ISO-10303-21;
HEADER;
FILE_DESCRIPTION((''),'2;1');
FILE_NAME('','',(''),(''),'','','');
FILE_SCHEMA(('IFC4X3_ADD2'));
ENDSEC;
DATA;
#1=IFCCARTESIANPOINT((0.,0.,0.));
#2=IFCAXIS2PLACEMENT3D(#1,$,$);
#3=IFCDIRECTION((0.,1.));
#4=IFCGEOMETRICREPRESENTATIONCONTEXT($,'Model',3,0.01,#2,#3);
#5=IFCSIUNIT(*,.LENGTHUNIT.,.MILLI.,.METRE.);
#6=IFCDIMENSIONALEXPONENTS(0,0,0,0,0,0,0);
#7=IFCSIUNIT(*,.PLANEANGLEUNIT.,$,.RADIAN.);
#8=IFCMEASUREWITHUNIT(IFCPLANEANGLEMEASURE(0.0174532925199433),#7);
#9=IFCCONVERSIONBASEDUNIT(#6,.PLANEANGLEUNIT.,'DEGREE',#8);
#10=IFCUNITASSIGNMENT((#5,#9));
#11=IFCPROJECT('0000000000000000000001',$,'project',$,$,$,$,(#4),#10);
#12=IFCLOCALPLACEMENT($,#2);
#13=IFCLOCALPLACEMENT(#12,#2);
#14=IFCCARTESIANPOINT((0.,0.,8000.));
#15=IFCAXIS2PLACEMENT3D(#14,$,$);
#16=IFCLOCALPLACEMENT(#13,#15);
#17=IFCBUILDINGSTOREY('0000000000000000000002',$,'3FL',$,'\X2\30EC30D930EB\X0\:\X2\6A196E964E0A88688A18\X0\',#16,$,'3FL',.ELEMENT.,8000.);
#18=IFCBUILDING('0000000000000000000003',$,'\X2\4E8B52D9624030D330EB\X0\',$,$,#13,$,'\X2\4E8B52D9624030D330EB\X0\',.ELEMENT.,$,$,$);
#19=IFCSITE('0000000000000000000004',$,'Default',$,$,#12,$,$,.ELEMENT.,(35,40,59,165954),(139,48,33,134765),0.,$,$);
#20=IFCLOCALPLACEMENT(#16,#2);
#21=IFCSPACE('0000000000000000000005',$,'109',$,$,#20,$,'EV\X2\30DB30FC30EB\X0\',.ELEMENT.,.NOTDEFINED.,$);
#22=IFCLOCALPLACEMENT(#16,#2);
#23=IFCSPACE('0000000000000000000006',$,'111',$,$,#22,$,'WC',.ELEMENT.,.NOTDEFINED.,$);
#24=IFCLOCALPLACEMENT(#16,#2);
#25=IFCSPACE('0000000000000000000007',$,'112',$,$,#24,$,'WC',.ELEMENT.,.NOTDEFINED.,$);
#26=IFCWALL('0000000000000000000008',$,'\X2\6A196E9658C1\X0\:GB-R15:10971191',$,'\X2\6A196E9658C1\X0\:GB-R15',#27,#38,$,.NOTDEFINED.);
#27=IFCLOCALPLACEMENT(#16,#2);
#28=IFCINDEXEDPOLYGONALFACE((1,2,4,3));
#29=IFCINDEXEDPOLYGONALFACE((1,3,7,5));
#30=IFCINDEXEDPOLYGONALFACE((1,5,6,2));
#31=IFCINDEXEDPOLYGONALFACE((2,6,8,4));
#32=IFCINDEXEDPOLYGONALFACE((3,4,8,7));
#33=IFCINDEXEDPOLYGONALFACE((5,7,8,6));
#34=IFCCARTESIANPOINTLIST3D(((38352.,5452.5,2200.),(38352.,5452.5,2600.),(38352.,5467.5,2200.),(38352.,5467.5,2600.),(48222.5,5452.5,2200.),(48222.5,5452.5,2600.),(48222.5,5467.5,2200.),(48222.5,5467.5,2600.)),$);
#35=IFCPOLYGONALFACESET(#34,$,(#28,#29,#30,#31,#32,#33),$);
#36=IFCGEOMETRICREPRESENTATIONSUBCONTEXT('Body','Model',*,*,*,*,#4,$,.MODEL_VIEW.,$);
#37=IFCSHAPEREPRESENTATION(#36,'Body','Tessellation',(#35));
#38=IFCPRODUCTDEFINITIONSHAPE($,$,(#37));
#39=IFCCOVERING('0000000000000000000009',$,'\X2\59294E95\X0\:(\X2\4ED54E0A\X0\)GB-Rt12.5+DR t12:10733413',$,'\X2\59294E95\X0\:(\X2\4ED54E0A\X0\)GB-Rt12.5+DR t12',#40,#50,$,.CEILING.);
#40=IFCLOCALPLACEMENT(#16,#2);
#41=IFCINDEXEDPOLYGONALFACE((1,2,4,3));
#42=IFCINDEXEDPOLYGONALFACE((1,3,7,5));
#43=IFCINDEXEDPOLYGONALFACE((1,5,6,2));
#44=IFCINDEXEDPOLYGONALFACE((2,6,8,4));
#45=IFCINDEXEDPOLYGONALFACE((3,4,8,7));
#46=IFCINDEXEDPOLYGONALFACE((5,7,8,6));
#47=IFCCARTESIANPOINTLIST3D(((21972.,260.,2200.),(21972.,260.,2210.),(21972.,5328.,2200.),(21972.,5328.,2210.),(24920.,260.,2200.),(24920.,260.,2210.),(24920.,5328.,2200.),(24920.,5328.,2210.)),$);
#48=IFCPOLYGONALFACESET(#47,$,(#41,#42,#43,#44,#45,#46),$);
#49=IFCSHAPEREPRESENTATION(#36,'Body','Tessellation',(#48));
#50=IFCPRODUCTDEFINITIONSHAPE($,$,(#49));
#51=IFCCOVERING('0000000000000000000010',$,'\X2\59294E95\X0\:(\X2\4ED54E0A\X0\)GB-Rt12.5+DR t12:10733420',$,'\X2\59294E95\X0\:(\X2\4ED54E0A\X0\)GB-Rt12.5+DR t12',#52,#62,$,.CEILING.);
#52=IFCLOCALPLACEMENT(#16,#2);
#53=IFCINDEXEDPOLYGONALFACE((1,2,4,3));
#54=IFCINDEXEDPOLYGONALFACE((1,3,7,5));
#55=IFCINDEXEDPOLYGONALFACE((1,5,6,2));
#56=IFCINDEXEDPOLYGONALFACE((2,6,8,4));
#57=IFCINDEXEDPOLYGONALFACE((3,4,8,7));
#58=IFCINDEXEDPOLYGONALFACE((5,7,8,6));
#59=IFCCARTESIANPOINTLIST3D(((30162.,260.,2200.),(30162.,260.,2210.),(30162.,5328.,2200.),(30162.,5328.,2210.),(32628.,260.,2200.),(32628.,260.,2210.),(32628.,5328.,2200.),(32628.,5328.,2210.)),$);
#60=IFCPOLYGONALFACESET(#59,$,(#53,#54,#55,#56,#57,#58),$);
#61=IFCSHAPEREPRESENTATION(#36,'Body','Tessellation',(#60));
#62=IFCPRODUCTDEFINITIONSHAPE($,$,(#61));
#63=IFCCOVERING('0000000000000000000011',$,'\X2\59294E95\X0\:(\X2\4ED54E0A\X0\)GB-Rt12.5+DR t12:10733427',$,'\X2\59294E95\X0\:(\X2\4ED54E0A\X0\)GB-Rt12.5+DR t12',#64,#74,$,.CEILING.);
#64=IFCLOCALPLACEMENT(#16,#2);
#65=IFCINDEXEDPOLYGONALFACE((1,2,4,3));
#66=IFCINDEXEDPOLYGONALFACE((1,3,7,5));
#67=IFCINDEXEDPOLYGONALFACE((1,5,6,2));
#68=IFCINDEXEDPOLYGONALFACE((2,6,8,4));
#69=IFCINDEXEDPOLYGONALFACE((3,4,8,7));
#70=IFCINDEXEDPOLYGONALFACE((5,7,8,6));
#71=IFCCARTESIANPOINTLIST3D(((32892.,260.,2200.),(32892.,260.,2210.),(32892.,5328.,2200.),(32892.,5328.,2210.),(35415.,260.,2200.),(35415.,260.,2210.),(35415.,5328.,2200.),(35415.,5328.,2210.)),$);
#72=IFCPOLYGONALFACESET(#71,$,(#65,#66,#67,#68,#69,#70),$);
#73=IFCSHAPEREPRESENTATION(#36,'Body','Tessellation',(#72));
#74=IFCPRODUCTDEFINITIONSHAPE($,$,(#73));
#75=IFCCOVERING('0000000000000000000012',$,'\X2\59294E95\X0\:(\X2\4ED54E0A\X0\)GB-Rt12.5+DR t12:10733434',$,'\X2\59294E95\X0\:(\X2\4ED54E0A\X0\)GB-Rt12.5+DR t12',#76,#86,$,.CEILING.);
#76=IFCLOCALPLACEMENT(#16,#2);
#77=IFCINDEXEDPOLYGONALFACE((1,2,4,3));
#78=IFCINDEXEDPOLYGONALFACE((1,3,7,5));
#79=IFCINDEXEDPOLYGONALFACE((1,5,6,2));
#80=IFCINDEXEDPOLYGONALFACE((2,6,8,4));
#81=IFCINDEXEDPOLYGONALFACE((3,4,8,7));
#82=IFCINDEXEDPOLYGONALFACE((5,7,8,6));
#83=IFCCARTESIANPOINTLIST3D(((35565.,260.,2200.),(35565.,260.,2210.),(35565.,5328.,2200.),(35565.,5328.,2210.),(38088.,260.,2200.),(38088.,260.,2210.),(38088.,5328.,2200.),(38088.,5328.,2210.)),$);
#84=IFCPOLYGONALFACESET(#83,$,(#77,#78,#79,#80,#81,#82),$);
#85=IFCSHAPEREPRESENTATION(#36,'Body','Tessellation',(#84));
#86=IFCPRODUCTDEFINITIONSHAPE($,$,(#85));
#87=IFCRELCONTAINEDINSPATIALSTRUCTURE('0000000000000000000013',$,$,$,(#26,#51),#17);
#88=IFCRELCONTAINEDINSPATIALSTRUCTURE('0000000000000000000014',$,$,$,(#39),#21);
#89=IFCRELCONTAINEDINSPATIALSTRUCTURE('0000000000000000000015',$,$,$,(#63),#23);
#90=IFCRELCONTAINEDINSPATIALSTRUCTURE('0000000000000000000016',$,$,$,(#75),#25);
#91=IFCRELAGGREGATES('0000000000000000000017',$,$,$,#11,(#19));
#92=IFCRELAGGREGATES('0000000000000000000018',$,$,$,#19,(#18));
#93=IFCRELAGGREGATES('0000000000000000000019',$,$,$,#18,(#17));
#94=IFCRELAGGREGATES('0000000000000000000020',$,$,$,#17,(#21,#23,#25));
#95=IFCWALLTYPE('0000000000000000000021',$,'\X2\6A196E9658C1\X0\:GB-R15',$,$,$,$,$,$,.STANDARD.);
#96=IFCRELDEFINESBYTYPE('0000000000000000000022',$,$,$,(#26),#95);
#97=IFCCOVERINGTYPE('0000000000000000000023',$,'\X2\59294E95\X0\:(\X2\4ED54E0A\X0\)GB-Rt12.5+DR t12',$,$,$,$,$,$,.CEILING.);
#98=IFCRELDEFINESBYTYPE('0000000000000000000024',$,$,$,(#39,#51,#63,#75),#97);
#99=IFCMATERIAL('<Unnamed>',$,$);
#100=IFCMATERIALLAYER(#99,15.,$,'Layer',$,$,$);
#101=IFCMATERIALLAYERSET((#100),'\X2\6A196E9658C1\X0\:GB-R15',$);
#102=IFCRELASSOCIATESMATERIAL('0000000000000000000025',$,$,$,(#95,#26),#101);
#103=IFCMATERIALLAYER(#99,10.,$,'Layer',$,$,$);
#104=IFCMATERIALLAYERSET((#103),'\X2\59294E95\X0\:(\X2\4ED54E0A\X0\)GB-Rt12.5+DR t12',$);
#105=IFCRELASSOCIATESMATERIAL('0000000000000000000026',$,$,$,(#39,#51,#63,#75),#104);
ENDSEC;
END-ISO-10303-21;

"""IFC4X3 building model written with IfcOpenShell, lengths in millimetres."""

from ifc_helpers import new_model, entity, si_unit, converted_unit, direction, frame, frame_2d, origin, place, context, subcontext, project, spatial, rectangle, extrude, material, layer, layer_set, layer_usage, type_object, element, save


model = new_model("IFC4X3")

# Units and contexts
model_context = context("Model", 3, precision=0.01, world=origin(), true_north=direction((0.0, 1.0)))
body_context = subcontext(model_context, "Body", "Model", "MODEL_VIEW")
ifc_project = project(units=[si_unit("LENGTHUNIT", "METRE", prefix="MILLI"), converted_unit("PLANEANGLEUNIT", "DEGREE", entity("IfcPlaneAngleMeasure", 0.0174532925199433), si_unit("PLANEANGLEUNIT", "RADIAN"), dimensions=[0, 0, 0, 0, 0, 0, 0])], contexts=[model_context])

# Site, building, storey
site_placement = place(None, origin())
site = spatial("IfcSite", under=ifc_project, at=site_placement, Name="Default", CompositionType="ELEMENT", RefLatitude=(35, 40, 59, 165954), RefLongitude=(139, 48, 33, 134765), RefElevation=0.0)
building_placement = place(site_placement, origin())
building = spatial("IfcBuilding", under=site, at=building_placement, Name="事務所ビル", LongName="事務所ビル", CompositionType="ELEMENT")
storey_placement = place(building_placement, frame((0.0, 0.0, 8000.0)))
storey = spatial("IfcBuildingStorey", under=building, at=storey_placement, Name="3FL", ObjectType="レベル:標準上表記", LongName="3FL", CompositionType="ELEMENT", Elevation=8000.0)

# Wall
ifc_material_1 = material(Name="<Unnamed>")
ifc_layer_1 = layer(ifc_material_1, 15.0, Name="Layer")
ifc_layer_set_1 = layer_set([ifc_layer_1], Name="標準壁:GB-R15")
wall_type_1 = type_object("IfcWallType", Name="標準壁:GB-R15", PredefinedType="STANDARD", material=ifc_layer_set_1)
wall_1_placement = place(storey_placement, frame((48222.5, 5460.0, 2200.0), z_axis=(0.0, 0.0, 1.0), x_axis=(-1.0, 0.0, 0.0)))
element("IfcWall", 1, at=wall_1_placement, inside=storey, type_object=wall_type_1, material=ifc_layer_set_1, Name="標準壁:GB-R15:10971191", ObjectType="標準壁:GB-R15", PredefinedType="NOTDEFINED", context=body_context, shape_type="SweptSolid", body=[
    extrude(rectangle(XDim=9870.5, YDim=15.0, at=frame_2d((4935.2, 0.0), x_axis=(-1.0, 0.0))), origin(), (0.0, 0.0, 1.0), 400.0),
])

# Shared definitions
space_1_placement = place(storey_placement, origin())
space_1 = spatial("IfcSpace", under=storey, at=space_1_placement, Name="109", LongName="EVホール", CompositionType="ELEMENT", PredefinedType="NOTDEFINED")

# Coverings
ifc_layer_2 = layer(ifc_material_1, 10.0, Name="Layer")
ifc_layer_set_2 = layer_set([ifc_layer_2], Name="天井:(仕上)GB-Rt12.5+DR t12")
ifc_layer_usage_1 = layer_usage(ifc_layer_set_2, "AXIS3", "NEGATIVE", 0.0)
covering_type = type_object("IfcCoveringType", Name="天井:(仕上)GB-Rt12.5+DR t12", PredefinedType="CEILING")
covering_1_placement = place(space_1_placement, frame((21972.0, 260.0, 2200.0)))
element("IfcCovering", 2, at=covering_1_placement, inside=space_1, type_object=covering_type, material=ifc_layer_usage_1, Name="天井:(仕上)GB-Rt12.5+DR t12:10733413", ObjectType="天井:(仕上)GB-Rt12.5+DR t12", PredefinedType="CEILING", context=body_context, shape_type="SweptSolid", body=[
    extrude(rectangle(XDim=2948.0, YDim=5068.0, at=frame_2d((0.0, 0.0), x_axis=(1.0, 0.0))), frame((1474.0, 2534.0, 0.0), z_axis=(0.0, 0.0, 1.0), x_axis=(-1.0, 0.0, 0.0)), (0.0, 0.0, 1.0), 10.0),
])
ifc_layer_usage_2 = layer_usage(ifc_layer_set_2, "AXIS3", "NEGATIVE", 0.0)
covering_2_placement = place(storey_placement, frame((30162.0, 260.0, 2200.0)))
element("IfcCovering", 3, at=covering_2_placement, inside=storey, type_object=covering_type, material=ifc_layer_usage_2, Name="天井:(仕上)GB-Rt12.5+DR t12:10733420", ObjectType="天井:(仕上)GB-Rt12.5+DR t12", PredefinedType="CEILING", context=body_context, shape_type="SweptSolid", body=[
    extrude(rectangle(XDim=2466.0, YDim=5068.0, at=frame_2d((0.0, 0.0), x_axis=(1.0, 0.0))), frame((1233.0, 2534.0, 0.0), z_axis=(0.0, 0.0, 1.0), x_axis=(-1.0, 0.0, 0.0)), (0.0, 0.0, 1.0), 10.0),
])

# Shared definitions
space_2_placement = place(storey_placement, origin())
space_2 = spatial("IfcSpace", under=storey, at=space_2_placement, Name="111", LongName="WC", CompositionType="ELEMENT", PredefinedType="NOTDEFINED")

# Covering
ifc_layer_usage_3 = layer_usage(ifc_layer_set_2, "AXIS3", "NEGATIVE", 0.0)
covering_3_placement = place(space_2_placement, frame((32892.0, 260.0, 2200.0)))
element("IfcCovering", 4, at=covering_3_placement, inside=space_2, type_object=covering_type, material=ifc_layer_usage_3, Name="天井:(仕上)GB-Rt12.5+DR t12:10733427", ObjectType="天井:(仕上)GB-Rt12.5+DR t12", PredefinedType="CEILING", context=body_context, shape_type="SweptSolid", body=[
    extrude(rectangle(XDim=2523.0, YDim=5068.0, at=frame_2d((0.0, 0.0), x_axis=(1.0, 0.0))), frame((1261.5, 2534.0, 0.0), z_axis=(0.0, 0.0, 1.0), x_axis=(-1.0, 0.0, 0.0)), (0.0, 0.0, 1.0), 10.0),
])

# Shared definitions
space_3_placement = place(storey_placement, origin())
space_3 = spatial("IfcSpace", under=storey, at=space_3_placement, Name="112", LongName="WC", CompositionType="ELEMENT", PredefinedType="NOTDEFINED")

# Covering
ifc_layer_usage_4 = layer_usage(ifc_layer_set_2, "AXIS3", "NEGATIVE", 0.0)
covering_4_placement = place(space_3_placement, frame((35565.0, 260.0, 2200.0)))
element("IfcCovering", 5, at=covering_4_placement, inside=space_3, type_object=covering_type, material=ifc_layer_usage_4, Name="天井:(仕上)GB-Rt12.5+DR t12:10733434", ObjectType="天井:(仕上)GB-Rt12.5+DR t12", PredefinedType="CEILING", context=body_context, shape_type="SweptSolid", body=[
    extrude(rectangle(XDim=2523.0, YDim=5068.0, at=frame_2d((0.0, 0.0), x_axis=(1.0, 0.0))), frame((1261.5, 2534.0, 0.0), z_axis=(0.0, 0.0, 1.0), x_axis=(-1.0, 0.0, 0.0)), (0.0, 0.0, 1.0), 10.0),
])

save(model, "model.ifc")
